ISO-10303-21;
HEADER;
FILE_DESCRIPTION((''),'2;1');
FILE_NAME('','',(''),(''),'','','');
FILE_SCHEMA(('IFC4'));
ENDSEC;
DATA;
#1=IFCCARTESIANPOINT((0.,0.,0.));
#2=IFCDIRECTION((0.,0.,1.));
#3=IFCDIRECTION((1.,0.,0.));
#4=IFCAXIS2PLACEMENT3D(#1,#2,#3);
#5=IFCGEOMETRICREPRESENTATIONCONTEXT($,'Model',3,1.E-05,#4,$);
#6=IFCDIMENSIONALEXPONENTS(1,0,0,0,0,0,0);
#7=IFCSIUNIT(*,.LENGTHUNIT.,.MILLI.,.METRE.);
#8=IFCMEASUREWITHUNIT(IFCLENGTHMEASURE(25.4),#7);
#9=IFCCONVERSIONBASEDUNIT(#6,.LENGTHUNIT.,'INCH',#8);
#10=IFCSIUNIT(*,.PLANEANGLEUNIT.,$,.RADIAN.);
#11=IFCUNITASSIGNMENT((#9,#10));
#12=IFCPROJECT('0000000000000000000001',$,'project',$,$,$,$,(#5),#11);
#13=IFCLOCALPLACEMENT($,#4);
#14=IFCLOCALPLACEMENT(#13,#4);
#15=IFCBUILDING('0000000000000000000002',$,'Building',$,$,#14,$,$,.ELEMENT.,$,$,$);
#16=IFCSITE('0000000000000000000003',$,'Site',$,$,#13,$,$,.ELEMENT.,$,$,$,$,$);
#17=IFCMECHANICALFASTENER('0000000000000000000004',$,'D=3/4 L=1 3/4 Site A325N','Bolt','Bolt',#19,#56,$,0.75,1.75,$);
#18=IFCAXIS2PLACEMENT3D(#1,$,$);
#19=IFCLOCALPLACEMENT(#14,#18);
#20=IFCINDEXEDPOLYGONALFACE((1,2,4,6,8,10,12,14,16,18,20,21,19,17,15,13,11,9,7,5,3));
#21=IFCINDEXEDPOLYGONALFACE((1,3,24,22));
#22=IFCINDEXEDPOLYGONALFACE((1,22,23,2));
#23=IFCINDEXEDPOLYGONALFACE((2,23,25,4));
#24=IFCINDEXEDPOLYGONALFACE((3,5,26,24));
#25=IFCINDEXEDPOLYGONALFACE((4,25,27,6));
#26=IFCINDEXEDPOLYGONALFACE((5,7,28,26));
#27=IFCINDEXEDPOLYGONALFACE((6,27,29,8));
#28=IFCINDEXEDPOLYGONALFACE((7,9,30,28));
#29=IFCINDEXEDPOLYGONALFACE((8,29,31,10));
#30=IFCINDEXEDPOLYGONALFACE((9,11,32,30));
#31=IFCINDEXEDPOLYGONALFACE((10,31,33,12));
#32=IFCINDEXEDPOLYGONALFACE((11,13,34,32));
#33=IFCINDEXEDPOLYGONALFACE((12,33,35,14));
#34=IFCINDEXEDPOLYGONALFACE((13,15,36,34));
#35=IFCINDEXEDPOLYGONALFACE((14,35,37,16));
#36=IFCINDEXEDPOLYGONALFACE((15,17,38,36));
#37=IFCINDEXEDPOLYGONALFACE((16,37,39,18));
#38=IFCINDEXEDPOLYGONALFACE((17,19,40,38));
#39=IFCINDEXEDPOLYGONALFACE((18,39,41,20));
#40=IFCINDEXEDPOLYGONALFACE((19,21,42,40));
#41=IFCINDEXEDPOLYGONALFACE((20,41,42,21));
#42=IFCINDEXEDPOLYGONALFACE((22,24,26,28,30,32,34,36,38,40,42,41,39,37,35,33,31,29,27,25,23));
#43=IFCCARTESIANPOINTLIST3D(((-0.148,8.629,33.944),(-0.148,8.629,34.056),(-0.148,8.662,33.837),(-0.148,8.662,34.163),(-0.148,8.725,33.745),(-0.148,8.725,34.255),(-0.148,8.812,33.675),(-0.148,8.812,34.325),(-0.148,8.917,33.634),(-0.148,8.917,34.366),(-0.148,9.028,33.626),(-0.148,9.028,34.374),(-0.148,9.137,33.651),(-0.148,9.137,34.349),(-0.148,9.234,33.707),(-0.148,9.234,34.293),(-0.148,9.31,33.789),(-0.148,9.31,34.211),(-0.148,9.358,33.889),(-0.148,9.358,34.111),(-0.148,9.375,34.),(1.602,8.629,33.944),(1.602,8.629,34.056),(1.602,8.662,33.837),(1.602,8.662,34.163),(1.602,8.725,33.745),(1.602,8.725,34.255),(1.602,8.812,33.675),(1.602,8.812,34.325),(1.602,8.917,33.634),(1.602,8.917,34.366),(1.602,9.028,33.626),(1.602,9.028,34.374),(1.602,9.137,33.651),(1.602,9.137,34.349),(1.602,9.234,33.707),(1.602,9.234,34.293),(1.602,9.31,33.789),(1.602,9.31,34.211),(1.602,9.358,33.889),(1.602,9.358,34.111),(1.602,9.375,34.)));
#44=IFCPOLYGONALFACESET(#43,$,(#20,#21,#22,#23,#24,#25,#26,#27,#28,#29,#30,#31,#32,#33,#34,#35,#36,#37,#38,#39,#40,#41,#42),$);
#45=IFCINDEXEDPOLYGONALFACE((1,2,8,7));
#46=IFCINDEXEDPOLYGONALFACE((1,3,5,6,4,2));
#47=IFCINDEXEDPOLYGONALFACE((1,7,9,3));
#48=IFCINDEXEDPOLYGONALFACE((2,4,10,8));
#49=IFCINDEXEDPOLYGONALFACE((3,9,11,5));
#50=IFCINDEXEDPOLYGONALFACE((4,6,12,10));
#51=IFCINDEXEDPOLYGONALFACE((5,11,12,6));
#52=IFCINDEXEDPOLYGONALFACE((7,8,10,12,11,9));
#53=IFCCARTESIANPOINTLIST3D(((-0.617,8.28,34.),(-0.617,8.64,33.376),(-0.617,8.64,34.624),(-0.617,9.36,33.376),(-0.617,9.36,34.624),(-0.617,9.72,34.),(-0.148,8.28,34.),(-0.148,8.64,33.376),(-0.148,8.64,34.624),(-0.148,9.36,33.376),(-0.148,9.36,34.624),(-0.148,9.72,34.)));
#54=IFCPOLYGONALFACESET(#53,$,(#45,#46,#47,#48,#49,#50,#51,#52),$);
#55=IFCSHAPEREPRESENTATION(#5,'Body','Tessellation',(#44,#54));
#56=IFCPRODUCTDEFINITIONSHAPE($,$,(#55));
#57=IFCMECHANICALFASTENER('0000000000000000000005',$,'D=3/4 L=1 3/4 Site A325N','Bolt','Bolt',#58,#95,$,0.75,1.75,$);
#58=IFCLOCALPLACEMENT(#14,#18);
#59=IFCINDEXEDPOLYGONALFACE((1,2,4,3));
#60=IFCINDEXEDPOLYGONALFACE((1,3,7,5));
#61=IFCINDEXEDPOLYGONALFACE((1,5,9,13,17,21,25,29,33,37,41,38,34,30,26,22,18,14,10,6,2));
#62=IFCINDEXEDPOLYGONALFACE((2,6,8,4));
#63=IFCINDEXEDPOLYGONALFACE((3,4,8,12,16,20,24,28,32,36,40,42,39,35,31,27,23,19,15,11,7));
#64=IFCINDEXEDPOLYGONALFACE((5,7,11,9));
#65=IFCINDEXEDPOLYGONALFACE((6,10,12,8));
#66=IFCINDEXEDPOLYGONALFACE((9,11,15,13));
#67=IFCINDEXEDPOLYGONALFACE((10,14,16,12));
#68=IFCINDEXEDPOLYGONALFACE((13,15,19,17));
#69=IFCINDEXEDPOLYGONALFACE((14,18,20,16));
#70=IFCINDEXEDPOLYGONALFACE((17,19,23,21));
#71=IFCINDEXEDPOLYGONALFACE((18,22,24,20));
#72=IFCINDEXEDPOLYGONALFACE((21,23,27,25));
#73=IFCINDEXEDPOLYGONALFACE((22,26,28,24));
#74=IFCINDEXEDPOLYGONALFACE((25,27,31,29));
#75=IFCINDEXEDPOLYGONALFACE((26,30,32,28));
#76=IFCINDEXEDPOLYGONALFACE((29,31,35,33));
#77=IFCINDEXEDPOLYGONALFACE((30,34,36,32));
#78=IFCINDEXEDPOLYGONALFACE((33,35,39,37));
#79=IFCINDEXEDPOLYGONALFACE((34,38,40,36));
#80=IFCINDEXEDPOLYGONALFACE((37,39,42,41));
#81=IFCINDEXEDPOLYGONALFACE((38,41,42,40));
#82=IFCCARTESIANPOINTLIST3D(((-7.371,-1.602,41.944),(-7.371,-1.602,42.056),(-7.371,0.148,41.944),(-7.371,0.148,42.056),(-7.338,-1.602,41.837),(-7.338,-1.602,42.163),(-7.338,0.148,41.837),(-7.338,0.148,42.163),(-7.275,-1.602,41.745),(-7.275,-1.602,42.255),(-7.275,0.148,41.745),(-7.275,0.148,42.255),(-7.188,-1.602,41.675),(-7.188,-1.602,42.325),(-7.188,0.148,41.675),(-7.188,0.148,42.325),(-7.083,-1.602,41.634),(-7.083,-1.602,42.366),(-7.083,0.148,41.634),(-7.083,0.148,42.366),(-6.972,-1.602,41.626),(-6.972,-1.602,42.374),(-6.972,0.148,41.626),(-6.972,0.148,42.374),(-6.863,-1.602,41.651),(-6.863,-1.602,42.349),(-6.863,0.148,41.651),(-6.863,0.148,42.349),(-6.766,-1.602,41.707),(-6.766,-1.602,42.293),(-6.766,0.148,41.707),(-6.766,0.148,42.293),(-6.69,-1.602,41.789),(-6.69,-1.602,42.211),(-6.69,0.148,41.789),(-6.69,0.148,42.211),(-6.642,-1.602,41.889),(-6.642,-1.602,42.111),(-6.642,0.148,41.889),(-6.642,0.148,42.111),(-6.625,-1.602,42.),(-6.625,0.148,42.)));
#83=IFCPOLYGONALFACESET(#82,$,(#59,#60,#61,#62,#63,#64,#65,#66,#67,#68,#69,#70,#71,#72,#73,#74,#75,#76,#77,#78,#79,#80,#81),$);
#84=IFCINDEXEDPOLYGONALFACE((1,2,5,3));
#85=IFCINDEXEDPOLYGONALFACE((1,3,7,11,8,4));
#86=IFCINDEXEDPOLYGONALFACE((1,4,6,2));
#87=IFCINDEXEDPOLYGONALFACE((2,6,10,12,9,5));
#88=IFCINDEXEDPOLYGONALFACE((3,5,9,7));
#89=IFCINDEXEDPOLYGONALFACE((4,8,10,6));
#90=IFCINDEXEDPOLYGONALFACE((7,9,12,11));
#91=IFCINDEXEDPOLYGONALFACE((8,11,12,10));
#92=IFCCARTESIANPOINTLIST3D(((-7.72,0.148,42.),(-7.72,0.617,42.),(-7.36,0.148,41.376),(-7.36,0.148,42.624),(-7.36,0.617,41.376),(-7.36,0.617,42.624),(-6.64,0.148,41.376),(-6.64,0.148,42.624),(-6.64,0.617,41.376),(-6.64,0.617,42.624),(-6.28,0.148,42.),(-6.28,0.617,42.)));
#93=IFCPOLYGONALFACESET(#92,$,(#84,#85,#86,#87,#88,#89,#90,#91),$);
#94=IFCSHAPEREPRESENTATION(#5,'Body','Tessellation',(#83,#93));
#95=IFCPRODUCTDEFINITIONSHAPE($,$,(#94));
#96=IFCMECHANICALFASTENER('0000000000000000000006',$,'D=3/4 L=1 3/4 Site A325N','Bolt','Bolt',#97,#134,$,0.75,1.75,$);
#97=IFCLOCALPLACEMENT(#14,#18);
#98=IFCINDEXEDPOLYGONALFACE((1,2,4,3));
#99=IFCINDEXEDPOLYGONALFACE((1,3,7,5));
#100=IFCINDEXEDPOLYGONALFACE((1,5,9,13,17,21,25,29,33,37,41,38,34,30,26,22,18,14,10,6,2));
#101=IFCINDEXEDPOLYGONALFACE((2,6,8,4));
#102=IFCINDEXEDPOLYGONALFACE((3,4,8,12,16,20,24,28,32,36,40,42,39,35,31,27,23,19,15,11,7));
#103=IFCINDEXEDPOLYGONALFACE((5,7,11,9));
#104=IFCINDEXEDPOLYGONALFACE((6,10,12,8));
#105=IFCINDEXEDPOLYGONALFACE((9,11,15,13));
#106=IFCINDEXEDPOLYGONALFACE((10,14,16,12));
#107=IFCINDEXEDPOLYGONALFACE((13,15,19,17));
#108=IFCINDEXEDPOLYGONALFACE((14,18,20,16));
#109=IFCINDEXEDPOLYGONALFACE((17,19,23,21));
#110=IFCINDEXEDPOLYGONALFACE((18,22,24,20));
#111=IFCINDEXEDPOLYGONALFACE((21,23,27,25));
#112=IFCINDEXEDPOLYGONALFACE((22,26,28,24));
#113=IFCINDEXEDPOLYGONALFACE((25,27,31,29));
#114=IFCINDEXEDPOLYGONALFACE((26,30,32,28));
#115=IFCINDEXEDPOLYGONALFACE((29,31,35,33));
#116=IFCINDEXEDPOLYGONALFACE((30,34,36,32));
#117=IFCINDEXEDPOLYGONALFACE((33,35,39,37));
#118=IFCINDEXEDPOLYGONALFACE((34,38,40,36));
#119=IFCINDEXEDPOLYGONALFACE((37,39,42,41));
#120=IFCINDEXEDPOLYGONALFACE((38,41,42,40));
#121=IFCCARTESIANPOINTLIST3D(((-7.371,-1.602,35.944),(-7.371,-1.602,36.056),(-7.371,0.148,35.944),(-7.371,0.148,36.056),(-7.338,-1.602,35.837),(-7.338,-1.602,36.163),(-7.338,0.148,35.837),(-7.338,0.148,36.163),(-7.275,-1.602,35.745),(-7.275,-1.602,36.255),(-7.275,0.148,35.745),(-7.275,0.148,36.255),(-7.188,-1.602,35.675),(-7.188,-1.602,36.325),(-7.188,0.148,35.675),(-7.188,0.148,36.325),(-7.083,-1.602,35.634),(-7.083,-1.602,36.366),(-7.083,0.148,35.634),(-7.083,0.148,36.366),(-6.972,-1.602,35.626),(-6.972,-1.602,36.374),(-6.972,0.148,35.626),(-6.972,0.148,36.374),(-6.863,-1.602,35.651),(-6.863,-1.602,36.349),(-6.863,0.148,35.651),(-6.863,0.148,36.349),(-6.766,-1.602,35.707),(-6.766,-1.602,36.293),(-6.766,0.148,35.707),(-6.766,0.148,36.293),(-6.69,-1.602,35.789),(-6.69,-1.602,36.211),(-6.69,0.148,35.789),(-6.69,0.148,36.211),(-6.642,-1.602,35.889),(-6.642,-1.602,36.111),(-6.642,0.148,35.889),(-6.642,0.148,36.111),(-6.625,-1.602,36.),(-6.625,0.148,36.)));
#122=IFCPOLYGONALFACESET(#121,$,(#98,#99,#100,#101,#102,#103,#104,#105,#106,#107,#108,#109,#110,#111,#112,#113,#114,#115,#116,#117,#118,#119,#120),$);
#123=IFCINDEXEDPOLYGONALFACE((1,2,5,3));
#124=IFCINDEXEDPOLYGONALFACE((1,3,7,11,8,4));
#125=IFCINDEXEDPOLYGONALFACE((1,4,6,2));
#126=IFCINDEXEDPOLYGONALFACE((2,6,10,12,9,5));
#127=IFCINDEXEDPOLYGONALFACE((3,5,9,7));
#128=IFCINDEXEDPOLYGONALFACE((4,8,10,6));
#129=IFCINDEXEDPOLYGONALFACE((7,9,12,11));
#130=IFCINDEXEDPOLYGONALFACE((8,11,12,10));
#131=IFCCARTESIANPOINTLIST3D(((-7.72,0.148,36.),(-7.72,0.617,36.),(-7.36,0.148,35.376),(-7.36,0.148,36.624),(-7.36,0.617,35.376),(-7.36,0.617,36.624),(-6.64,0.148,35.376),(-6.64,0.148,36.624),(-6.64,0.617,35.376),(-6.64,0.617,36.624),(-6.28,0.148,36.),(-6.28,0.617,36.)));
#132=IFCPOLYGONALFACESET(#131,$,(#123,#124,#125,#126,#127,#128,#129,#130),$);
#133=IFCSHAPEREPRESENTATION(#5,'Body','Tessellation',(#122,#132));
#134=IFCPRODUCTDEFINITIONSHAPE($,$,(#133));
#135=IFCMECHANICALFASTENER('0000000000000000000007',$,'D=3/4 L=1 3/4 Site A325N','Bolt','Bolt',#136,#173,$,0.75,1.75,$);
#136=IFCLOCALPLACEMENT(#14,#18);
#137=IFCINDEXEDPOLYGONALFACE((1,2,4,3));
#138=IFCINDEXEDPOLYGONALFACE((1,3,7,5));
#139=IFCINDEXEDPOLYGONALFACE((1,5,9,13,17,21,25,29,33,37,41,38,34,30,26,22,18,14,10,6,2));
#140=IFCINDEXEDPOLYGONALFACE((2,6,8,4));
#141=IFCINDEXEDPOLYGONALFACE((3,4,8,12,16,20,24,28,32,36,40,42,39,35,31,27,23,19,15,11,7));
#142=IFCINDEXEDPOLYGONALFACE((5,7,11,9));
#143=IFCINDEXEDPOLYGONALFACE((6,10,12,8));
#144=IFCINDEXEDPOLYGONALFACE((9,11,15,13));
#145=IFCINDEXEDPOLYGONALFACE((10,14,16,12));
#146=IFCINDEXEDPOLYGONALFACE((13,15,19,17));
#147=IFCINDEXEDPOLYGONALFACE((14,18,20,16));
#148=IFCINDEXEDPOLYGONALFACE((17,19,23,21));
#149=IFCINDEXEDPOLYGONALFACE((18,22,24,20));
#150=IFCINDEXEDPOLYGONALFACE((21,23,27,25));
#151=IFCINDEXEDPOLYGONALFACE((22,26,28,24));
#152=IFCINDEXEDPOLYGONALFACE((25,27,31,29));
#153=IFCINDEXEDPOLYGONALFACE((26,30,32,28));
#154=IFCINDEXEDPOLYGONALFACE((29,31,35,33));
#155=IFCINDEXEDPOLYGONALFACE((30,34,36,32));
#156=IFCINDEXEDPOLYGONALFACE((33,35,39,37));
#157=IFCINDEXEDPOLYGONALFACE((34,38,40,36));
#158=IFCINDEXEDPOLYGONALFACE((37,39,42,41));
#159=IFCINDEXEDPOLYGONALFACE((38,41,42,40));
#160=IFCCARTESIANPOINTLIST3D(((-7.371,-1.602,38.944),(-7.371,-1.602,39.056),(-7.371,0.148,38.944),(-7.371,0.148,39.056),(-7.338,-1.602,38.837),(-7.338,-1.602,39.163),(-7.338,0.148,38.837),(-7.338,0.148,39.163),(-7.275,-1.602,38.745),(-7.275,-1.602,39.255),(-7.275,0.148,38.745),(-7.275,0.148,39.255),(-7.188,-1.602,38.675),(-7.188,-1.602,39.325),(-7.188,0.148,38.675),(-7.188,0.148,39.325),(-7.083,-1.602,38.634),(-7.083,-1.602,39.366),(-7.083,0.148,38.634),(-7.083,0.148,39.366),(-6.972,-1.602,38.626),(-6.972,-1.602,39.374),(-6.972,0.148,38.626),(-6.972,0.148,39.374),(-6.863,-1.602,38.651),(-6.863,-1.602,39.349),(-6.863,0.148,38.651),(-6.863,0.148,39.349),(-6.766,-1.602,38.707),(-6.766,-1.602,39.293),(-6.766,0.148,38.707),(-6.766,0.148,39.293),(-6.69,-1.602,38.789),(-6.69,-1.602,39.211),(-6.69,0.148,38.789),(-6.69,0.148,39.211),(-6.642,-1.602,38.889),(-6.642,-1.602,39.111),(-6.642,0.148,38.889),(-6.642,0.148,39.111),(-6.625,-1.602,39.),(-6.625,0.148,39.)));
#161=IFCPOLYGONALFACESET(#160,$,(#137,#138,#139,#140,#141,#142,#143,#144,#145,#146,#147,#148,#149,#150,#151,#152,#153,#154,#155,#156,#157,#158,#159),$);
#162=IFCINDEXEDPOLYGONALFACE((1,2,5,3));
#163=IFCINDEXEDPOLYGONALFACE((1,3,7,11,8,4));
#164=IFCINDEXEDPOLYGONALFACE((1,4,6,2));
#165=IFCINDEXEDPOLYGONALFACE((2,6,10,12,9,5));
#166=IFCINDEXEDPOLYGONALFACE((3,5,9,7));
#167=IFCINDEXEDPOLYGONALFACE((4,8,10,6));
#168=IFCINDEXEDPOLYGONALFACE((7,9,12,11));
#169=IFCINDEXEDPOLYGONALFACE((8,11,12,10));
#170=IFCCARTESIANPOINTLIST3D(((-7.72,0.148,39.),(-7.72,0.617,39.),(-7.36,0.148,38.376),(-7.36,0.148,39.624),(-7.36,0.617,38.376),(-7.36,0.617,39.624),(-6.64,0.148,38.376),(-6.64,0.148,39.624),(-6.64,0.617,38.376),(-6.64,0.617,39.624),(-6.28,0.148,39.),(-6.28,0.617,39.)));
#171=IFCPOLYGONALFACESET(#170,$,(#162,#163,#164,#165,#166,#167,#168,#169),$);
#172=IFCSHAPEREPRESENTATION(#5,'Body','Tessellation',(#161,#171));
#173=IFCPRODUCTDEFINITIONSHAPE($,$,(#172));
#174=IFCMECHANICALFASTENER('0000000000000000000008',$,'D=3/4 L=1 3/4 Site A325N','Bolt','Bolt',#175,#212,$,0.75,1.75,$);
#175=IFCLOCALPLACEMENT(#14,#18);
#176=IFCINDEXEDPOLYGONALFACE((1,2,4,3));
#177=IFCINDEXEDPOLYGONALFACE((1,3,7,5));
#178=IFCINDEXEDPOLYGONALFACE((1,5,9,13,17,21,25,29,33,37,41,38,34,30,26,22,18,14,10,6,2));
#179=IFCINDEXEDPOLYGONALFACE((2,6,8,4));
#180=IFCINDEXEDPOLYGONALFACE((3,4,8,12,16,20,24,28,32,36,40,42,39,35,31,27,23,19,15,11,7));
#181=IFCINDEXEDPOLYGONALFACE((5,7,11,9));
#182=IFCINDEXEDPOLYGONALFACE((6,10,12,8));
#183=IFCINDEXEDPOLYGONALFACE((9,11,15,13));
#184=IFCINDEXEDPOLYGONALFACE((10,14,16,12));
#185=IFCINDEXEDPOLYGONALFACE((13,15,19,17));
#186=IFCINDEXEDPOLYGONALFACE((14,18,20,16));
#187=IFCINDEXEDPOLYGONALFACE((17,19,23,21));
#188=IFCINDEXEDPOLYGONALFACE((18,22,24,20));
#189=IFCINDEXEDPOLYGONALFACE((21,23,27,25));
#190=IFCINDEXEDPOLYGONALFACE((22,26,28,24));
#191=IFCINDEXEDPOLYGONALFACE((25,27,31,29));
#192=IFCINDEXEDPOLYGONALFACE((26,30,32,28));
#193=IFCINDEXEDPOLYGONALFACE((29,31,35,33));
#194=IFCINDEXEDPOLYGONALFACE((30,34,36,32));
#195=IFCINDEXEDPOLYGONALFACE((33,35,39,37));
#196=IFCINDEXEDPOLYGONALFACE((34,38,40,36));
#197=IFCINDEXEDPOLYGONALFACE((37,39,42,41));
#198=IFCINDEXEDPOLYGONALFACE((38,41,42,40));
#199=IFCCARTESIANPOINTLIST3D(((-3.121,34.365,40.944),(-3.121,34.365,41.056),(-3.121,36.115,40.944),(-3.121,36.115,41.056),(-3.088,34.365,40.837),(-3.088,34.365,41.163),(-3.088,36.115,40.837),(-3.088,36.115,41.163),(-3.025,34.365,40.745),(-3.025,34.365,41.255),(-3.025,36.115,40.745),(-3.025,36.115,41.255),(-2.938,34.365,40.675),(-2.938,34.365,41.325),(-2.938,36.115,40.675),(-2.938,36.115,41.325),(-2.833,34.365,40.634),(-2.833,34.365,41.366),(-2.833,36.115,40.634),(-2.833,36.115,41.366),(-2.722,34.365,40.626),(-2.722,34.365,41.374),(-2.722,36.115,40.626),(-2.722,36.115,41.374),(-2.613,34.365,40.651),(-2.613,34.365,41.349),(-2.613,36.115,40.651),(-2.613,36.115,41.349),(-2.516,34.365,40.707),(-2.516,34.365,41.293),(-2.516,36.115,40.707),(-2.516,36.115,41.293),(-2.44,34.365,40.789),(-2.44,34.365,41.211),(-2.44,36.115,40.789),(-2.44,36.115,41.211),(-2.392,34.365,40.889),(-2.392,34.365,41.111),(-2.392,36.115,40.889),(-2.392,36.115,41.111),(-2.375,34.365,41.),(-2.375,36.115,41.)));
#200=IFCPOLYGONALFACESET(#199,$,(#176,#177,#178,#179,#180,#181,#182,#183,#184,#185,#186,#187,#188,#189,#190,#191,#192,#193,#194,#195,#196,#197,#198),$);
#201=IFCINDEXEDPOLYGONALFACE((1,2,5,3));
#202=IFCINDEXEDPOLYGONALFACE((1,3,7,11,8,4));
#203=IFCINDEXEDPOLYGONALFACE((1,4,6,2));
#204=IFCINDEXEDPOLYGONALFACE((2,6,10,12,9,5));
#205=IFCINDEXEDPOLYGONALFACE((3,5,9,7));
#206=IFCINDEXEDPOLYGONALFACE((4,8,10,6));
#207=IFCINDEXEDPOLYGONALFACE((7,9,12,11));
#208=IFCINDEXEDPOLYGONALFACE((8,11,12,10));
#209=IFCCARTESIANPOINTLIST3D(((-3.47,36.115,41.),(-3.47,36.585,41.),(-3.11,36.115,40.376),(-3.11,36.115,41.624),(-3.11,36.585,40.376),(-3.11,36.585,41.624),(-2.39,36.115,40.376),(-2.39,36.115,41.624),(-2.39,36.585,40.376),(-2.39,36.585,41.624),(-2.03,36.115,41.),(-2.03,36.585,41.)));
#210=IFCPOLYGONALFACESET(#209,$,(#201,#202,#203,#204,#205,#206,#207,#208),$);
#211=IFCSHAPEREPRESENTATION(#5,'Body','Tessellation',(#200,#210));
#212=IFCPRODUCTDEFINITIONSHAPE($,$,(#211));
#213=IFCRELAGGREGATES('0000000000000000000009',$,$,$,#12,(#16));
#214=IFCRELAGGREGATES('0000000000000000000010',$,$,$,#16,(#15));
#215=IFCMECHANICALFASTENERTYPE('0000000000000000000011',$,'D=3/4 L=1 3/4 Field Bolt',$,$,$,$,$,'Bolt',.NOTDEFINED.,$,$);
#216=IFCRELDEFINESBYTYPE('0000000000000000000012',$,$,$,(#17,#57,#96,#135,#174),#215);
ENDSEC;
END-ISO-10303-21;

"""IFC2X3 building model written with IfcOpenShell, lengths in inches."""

from ifc_helpers import new_model, entity, si_unit, converted_unit, frame, origin_with_axes, origin_2d_with_axis, place, context, project, spatial, polyline, circle, outline, extrude, source, transform, mapped, type_object, type_shapes, element, save


model = new_model("IFC2X3")

# Units and contexts
model_context = context("Model", 3, precision=1e-05, world=origin_with_axes())
ifc_project = project(units=[converted_unit("LENGTHUNIT", "INCH", entity("IfcLengthMeasure", 25.4), si_unit("LENGTHUNIT", "METRE", prefix="MILLI"), dimensions=[1, 0, 0, 0, 0, 0, 0]), si_unit("PLANEANGLEUNIT", "RADIAN")], contexts=[model_context])

# Site, building
site_placement = place(None, origin_with_axes())
site = spatial("IfcSite", under=ifc_project, at=site_placement, Name="Site", CompositionType="ELEMENT")
building_placement = place(site_placement, origin_with_axes())
building = spatial("IfcBuilding", under=site, at=building_placement, Name="Building", CompositionType="ELEMENT")

# Mechanical fasteners
mechanical_fastener_type_1 = type_object("IfcMechanicalFastenerType", Name="D=3/4 L=1 3/4 Field Bolt", ElementType="Bolt")
shared_shape_1 = source(origin_with_axes(), model_context, "Body", "SweptSolid", [
    extrude(circle(Radius=0.375, at=origin_2d_with_axis()), frame((0.0, 0.0, 0.0), z_axis=(1.0, 0.0, 0.0), x_axis=(0.0, 1.0, 0.0)), (0.0, 0.0, 1.0), 1.75),
    extrude(outline(polyline([(-0.72, 0.0), (-0.36, 0.624), (0.36, 0.624), (0.72, 0.0), (0.36, -0.624), (-0.36, -0.624), (-0.72, 0.0)])), frame((0.0, 0.0, 0.0), z_axis=(1.0, 0.0, 0.0), x_axis=(0.0, 1.0, 0.0)), (0.0, 0.0, -1.0), 0.47),
])
type_shapes(mechanical_fastener_type_1, [shared_shape_1])
placement_1 = place(building_placement, frame((0.0, 0.0, 46.0), z_axis=(0.0, 0.0, 1.0), x_axis=(0.0, 1.0, 0.0)))
placement_2 = place(placement_1, frame((9.0, 0.148, -4.0), z_axis=(0.0, 0.0, 1.0), x_axis=(0.0, -1.0, 0.0)))
for number, where, z_axis, x_axis, name in (
    (1, (0.0, 0.0, -8.0), (0.0, 0.0, 1.0), (1.0, 0.0, 0.0), "D=3/4 L=1 3/4 Site A325N"),
):
    element("IfcMechanicalFastener", number, at=place(placement_2, frame(where, z_axis=z_axis, x_axis=x_axis)), type_object=mechanical_fastener_type_1, Name=name, Description="Bolt", ObjectType="Bolt", NominalDiameter=0.75, NominalLength=1.75, context=model_context, shape_type="MappedRepresentation", body=[
        mapped(shared_shape_1, transform((0.0, 0.0, 0.0), scale=1.0)),
    ])
placement_3 = place(building_placement, frame((0.0, 0.0, 46.0), z_axis=(0.0, 0.0, 1.0), x_axis=(-1.0, 0.0, 0.0)))
placement_4 = place(placement_3, frame((7.0, -0.148, -4.0), z_axis=(0.0, 0.0, 1.0), x_axis=(0.0, 1.0, 0.0)))
for number, where, z_axis, x_axis, name in (
    (2, (0.0, 0.0, 0.0), (0.0, 0.0, 1.0), (1.0, 0.0, 0.0), "D=3/4 L=1 3/4 Site A325N"),
    (3, (0.0, 0.0, -6.0), (0.0, 0.0, 1.0), (1.0, 0.0, 0.0), "D=3/4 L=1 3/4 Site A325N"),
    (4, (0.0, 0.0, -3.0), (0.0, 0.0, 1.0), (1.0, 0.0, 0.0), "D=3/4 L=1 3/4 Site A325N"),
):
    element("IfcMechanicalFastener", number, at=place(placement_4, frame(where, z_axis=z_axis, x_axis=x_axis)), type_object=mechanical_fastener_type_1, Name=name, Description="Bolt", ObjectType="Bolt", NominalDiameter=0.75, NominalLength=1.75, context=model_context, shape_type="MappedRepresentation", body=[
        mapped(shared_shape_1, transform((0.0, 0.0, 0.0), scale=1.0)),
    ])
placement_5 = place(building_placement, frame((0.0, 36.0, 44.0), z_axis=(0.0, 0.0, 1.0), x_axis=(-1.0, 0.0, 0.0)))
placement_6 = place(placement_5, frame((2.75, -0.115, -9.0), z_axis=(0.0, 0.0, 1.0), x_axis=(0.0, 1.0, 0.0)))
for number, where, z_axis, x_axis, name in (
    (5, (0.0, 0.0, 6.0), (0.0, 0.0, 1.0), (1.0, 0.0, 0.0), "D=3/4 L=1 3/4 Site A325N"),
):
    element("IfcMechanicalFastener", number, at=place(placement_6, frame(where, z_axis=z_axis, x_axis=x_axis)), type_object=mechanical_fastener_type_1, Name=name, Description="Bolt", ObjectType="Bolt", NominalDiameter=0.75, NominalLength=1.75, context=model_context, shape_type="MappedRepresentation", body=[
        mapped(shared_shape_1, transform((0.0, 0.0, 0.0), scale=1.0)),
    ])

save(model, "model.ifc")
